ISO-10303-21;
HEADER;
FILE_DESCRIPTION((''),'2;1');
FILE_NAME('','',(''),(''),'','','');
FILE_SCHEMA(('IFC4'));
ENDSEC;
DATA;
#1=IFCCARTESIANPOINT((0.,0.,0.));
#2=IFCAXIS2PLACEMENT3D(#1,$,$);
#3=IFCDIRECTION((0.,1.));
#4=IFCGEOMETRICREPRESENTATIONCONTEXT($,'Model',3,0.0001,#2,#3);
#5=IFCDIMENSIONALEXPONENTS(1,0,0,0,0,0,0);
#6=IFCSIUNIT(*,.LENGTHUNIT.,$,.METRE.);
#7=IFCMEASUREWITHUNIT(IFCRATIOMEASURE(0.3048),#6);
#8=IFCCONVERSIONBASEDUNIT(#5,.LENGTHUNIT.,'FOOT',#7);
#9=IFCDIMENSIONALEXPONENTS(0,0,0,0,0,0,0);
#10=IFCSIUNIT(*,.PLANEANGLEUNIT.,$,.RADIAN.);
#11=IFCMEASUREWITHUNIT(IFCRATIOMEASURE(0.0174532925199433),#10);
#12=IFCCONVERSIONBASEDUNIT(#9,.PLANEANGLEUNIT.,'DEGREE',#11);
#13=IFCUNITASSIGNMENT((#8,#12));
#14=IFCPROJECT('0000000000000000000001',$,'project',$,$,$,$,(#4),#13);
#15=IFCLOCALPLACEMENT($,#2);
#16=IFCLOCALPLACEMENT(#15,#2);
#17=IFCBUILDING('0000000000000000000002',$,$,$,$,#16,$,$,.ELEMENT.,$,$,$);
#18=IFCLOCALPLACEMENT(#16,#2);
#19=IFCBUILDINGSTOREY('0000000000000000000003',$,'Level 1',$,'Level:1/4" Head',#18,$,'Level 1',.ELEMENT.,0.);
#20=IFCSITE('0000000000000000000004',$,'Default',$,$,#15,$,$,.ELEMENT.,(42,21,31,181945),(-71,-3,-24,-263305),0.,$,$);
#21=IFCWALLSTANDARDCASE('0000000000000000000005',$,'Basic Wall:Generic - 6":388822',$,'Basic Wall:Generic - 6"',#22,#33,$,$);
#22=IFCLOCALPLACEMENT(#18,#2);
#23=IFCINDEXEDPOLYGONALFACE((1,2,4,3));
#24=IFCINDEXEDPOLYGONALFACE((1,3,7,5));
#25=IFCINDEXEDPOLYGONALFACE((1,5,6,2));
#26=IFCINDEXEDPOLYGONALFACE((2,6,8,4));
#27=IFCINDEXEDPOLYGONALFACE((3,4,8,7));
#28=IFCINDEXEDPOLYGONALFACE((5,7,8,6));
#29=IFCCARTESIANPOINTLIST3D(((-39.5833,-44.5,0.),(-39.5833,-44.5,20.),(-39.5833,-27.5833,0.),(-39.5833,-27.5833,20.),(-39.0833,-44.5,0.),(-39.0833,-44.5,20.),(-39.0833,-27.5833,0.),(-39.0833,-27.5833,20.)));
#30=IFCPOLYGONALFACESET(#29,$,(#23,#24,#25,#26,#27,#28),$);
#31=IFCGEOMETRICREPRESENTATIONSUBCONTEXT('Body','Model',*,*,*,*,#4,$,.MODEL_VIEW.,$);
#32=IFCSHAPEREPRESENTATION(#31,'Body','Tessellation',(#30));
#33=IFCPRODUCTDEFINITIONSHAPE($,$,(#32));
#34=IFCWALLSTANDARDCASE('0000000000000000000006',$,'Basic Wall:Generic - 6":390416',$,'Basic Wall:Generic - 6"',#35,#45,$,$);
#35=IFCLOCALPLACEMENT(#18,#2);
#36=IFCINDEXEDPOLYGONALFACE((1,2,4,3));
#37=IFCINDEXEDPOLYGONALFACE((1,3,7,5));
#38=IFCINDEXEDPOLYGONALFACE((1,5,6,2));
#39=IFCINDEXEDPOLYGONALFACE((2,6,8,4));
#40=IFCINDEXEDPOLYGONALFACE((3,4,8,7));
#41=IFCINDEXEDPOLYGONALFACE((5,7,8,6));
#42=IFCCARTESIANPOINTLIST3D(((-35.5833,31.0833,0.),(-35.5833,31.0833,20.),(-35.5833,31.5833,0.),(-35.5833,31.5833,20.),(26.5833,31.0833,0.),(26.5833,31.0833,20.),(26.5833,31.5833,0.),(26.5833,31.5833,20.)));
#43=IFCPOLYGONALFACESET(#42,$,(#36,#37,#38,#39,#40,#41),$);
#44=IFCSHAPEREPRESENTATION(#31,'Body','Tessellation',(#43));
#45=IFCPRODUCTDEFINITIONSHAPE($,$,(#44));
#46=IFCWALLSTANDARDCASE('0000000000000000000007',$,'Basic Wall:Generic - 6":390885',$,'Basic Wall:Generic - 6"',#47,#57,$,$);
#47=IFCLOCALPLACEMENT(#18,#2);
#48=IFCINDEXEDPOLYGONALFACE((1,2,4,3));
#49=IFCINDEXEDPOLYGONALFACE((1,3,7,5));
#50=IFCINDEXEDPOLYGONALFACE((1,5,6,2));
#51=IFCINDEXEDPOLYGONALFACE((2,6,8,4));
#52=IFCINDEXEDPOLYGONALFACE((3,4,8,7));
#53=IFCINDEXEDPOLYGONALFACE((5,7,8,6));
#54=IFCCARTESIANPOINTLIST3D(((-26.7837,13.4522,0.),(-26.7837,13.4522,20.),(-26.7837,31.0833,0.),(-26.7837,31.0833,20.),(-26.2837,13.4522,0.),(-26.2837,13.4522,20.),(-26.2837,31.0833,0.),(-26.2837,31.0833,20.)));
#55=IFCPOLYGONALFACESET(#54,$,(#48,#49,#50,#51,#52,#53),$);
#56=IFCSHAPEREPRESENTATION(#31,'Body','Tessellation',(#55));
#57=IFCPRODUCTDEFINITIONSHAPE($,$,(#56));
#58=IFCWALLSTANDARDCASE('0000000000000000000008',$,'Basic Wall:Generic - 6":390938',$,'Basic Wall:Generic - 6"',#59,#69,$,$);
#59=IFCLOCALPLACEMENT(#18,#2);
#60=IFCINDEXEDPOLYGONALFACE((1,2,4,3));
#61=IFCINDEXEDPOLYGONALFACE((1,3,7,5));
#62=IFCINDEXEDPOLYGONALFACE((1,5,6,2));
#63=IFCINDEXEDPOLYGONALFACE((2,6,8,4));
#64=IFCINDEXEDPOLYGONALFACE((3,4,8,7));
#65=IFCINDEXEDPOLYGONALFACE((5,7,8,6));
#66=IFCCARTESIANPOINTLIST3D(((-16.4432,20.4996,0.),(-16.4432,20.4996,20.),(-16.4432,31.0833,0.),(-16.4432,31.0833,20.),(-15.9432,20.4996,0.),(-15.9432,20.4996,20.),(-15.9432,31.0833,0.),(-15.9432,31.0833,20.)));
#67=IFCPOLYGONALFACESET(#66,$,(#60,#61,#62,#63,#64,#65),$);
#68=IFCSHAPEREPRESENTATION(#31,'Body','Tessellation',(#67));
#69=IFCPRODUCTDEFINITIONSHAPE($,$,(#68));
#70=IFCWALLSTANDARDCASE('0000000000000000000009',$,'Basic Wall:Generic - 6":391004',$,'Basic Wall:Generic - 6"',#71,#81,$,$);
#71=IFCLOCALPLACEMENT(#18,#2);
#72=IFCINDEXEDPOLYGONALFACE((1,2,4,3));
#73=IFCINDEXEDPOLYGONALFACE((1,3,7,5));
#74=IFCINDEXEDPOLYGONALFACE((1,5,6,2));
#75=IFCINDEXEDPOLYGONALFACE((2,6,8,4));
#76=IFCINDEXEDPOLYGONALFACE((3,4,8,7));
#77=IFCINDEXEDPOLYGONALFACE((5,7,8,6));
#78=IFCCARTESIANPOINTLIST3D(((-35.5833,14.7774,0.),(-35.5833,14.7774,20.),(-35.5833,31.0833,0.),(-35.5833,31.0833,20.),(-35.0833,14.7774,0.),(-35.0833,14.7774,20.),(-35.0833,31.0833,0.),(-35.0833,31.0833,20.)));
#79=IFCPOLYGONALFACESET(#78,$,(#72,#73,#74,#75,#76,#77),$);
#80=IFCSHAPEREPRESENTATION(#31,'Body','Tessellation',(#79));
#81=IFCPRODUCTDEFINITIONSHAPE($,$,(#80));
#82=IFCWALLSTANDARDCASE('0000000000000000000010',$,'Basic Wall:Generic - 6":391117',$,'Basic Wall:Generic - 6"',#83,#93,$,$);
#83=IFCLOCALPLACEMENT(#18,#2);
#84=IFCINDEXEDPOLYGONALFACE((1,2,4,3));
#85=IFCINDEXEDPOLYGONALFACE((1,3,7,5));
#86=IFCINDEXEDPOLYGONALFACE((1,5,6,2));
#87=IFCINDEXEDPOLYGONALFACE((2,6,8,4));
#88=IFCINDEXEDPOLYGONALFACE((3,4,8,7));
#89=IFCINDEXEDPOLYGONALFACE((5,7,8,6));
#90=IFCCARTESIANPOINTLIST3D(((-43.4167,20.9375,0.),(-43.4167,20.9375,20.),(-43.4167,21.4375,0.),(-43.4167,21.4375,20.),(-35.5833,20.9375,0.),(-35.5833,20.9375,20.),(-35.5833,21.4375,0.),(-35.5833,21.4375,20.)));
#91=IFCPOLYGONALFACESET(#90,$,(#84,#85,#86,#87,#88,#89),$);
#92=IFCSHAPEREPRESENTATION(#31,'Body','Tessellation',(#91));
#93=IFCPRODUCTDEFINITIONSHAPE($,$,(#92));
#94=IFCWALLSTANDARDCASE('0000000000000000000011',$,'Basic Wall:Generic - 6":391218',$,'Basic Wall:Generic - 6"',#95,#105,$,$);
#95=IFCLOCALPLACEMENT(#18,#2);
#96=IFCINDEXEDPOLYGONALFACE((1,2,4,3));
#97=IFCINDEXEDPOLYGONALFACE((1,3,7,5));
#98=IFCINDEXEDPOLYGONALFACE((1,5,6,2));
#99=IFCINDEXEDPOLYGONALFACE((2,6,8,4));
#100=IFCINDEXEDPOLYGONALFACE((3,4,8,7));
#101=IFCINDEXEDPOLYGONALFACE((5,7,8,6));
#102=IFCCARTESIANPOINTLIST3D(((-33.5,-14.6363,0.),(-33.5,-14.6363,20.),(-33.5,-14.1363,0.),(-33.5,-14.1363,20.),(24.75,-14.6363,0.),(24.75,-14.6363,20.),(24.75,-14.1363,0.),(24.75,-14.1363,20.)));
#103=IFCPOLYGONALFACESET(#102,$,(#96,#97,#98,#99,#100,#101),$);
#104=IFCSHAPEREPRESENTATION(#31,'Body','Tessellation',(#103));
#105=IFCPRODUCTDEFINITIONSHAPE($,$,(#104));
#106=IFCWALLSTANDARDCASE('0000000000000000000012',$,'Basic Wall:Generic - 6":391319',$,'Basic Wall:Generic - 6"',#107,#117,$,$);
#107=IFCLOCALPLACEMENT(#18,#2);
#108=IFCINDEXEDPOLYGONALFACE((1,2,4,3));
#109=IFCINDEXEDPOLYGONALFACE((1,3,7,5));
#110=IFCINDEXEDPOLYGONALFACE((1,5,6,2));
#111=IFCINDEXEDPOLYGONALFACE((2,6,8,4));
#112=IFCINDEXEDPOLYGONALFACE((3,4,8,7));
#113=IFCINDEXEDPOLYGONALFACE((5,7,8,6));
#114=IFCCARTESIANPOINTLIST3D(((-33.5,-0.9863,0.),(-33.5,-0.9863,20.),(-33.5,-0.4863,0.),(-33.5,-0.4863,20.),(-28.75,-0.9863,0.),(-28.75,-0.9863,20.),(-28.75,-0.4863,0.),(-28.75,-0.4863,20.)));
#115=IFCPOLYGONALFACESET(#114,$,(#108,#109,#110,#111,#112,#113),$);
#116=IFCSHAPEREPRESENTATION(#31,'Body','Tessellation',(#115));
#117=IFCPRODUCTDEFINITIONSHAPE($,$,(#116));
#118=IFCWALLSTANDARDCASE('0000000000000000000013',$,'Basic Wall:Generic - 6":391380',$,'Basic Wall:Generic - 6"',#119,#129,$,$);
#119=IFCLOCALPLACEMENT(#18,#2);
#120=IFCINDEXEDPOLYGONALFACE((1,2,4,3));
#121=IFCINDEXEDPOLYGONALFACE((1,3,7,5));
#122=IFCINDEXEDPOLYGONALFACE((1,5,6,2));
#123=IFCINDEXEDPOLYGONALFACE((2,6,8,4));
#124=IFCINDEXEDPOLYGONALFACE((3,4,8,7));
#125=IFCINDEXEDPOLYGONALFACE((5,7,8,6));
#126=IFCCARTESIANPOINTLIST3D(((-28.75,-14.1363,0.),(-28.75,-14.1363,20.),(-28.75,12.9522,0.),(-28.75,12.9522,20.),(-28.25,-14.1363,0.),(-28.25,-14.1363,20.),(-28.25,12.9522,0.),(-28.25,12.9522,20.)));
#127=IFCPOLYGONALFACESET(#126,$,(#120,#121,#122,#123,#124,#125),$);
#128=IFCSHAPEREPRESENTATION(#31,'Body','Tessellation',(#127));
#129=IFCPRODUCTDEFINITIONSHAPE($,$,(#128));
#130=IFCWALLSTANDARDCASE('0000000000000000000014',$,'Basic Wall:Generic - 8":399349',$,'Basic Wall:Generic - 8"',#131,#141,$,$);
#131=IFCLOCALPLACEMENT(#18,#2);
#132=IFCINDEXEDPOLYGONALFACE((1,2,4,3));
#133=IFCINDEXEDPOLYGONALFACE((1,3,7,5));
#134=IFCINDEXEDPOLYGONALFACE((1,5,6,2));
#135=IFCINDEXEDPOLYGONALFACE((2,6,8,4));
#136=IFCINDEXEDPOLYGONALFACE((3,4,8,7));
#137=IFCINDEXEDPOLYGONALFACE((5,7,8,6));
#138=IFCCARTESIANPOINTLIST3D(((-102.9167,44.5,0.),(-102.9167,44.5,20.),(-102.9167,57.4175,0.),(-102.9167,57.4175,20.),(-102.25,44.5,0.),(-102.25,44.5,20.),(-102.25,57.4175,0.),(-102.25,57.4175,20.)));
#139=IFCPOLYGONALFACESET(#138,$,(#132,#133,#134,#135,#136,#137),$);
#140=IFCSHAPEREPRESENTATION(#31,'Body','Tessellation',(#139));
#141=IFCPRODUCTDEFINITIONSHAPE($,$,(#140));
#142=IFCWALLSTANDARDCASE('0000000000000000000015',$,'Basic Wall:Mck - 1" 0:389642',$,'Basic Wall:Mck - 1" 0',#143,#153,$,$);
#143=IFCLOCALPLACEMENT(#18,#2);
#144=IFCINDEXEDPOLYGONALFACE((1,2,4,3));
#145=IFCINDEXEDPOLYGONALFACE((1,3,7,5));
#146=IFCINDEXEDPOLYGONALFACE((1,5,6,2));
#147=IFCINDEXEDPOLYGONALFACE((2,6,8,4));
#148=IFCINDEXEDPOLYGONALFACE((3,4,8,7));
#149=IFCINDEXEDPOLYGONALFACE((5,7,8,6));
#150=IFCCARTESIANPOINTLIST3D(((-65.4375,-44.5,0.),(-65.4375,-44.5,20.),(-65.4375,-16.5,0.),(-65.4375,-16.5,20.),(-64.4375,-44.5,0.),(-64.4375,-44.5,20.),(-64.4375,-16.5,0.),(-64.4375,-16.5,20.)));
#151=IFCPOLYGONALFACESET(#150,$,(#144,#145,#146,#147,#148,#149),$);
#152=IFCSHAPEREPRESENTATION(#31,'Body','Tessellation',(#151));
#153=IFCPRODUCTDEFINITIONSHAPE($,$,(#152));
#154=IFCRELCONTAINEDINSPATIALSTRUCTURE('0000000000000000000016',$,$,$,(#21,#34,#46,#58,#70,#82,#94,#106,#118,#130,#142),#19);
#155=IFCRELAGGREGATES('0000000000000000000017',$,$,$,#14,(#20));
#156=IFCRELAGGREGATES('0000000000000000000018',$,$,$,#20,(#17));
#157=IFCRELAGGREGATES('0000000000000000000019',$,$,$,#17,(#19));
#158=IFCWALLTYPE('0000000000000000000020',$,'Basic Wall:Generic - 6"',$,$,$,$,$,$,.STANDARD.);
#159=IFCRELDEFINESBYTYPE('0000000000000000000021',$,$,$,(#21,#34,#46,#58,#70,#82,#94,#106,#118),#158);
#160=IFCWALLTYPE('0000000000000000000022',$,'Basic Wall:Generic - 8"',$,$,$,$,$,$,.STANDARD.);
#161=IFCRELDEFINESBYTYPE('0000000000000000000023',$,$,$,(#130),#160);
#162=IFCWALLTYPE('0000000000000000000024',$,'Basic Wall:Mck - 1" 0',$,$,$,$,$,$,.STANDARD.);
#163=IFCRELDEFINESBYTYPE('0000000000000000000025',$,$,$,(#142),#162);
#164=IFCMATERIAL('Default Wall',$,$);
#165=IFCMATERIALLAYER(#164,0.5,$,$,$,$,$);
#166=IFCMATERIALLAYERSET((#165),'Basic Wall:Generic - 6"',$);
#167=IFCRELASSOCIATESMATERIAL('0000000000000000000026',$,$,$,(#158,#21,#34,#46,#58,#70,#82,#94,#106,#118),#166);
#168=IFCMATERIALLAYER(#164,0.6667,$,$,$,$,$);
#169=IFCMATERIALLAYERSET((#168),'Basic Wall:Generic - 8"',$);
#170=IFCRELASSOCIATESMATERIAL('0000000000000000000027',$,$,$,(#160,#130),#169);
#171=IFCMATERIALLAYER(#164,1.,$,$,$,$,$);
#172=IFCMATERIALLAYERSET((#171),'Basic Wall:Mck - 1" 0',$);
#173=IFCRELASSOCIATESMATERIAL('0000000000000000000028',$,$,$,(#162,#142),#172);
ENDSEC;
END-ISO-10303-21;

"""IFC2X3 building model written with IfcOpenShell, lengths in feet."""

from ifc_helpers import new_model, entity, si_unit, converted_unit, direction, frame, frame_2d, origin, place, context, subcontext, project, spatial, rectangle, extrude, material, layer, layer_set, layer_usage, type_object, element, save


model = new_model("IFC2X3")

# Units and contexts
model_context = context("Model", 3, precision=0.0001, world=origin(), true_north=direction((0.0, 1.0)))
body_context = subcontext(model_context, "Body", "Model", "MODEL_VIEW")
ifc_project = project(units=[converted_unit("LENGTHUNIT", "FOOT", entity("IfcRatioMeasure", 0.3048), si_unit("LENGTHUNIT", "METRE"), dimensions=[1, 0, 0, 0, 0, 0, 0]), converted_unit("PLANEANGLEUNIT", "DEGREE", entity("IfcRatioMeasure", 0.0174532925199433), si_unit("PLANEANGLEUNIT", "RADIAN"), dimensions=[0, 0, 0, 0, 0, 0, 0])], contexts=[model_context])

# Site, building, storey
site_placement = place(None, origin())
site = spatial("IfcSite", under=ifc_project, at=site_placement, Name="Default", CompositionType="ELEMENT", RefLatitude=(42, 21, 31, 181945), RefLongitude=(-71, -3, -24, -263305), RefElevation=0.0)
building_placement = place(site_placement, origin())
building = spatial("IfcBuilding", under=site, at=building_placement, CompositionType="ELEMENT")
storey_placement = place(building_placement, origin())
storey = spatial("IfcBuildingStorey", under=building, at=storey_placement, Name="Level 1", ObjectType="Level:1/4\" Head", LongName="Level 1", CompositionType="ELEMENT", Elevation=0.0)

# Walls
ifc_material = material(Name="Default Wall")
ifc_layer_1 = layer(ifc_material, 0.5)
ifc_layer_set_1 = layer_set([ifc_layer_1], Name="Basic Wall:Generic - 6\"")
wall_type_1 = type_object("IfcWallType", Name="Basic Wall:Generic - 6\"", PredefinedType="STANDARD", material=ifc_layer_set_1)
ifc_layer_usage_1 = layer_usage(ifc_layer_set_1, "AXIS2", "NEGATIVE", 0.25)
wall_1_placement = place(storey_placement, frame((-39.3333, -27.5833, 0.0), z_axis=(0.0, 0.0, 1.0), x_axis=(0.0, -1.0, 0.0)))
element("IfcWallStandardCase", 1, at=wall_1_placement, inside=storey, type_object=wall_type_1, material=ifc_layer_usage_1, Name="Basic Wall:Generic - 6\":388822", ObjectType="Basic Wall:Generic - 6\"", context=body_context, shape_type="SweptSolid", body=[
    extrude(rectangle(XDim=16.9167, YDim=0.5, at=frame_2d((8.4583, 0.0), x_axis=(-1.0, 0.0))), origin(), (0.0, 0.0, 1.0), 20.0),
])
ifc_layer_usage_2 = layer_usage(ifc_layer_set_1, "AXIS2", "NEGATIVE", 0.25)
wall_2_placement = place(storey_placement, frame((-35.5833, 31.3333, 0.0)))
element("IfcWallStandardCase", 2, at=wall_2_placement, inside=storey, type_object=wall_type_1, material=ifc_layer_usage_2, Name="Basic Wall:Generic - 6\":390416", ObjectType="Basic Wall:Generic - 6\"", context=body_context, shape_type="SweptSolid", body=[
    extrude(rectangle(XDim=62.1667, YDim=0.5, at=frame_2d((31.0833, 0.0), x_axis=(-1.0, 0.0))), origin(), (0.0, 0.0, 1.0), 20.0),
])
ifc_layer_usage_3 = layer_usage(ifc_layer_set_1, "AXIS2", "NEGATIVE", 0.25)
wall_3_placement = place(storey_placement, frame((-26.5337, 13.4522, 0.0), z_axis=(0.0, 0.0, 1.0), x_axis=(0.0, 1.0, 0.0)))
element("IfcWallStandardCase", 3, at=wall_3_placement, inside=storey, type_object=wall_type_1, material=ifc_layer_usage_3, Name="Basic Wall:Generic - 6\":390885", ObjectType="Basic Wall:Generic - 6\"", context=body_context, shape_type="SweptSolid", body=[
    extrude(rectangle(XDim=17.6311, YDim=0.5, at=frame_2d((8.8156, 0.0), x_axis=(-1.0, 0.0))), origin(), (0.0, 0.0, 1.0), 20.0),
])
ifc_layer_usage_4 = layer_usage(ifc_layer_set_1, "AXIS2", "NEGATIVE", 0.25)
wall_4_placement = place(storey_placement, frame((-16.1932, 31.0833, 0.0), z_axis=(0.0, 0.0, 1.0), x_axis=(0.0, -1.0, 0.0)))
element("IfcWallStandardCase", 4, at=wall_4_placement, inside=storey, type_object=wall_type_1, material=ifc_layer_usage_4, Name="Basic Wall:Generic - 6\":390938", ObjectType="Basic Wall:Generic - 6\"", context=body_context, shape_type="SweptSolid", body=[
    extrude(rectangle(XDim=10.5838, YDim=0.5, at=frame_2d((5.2919, 0.0), x_axis=(-1.0, 0.0))), origin(), (0.0, 0.0, 1.0), 20.0),
])
ifc_layer_usage_5 = layer_usage(ifc_layer_set_1, "AXIS2", "NEGATIVE", 0.25)
wall_5_placement = place(storey_placement, frame((-35.3333, 31.0833, 0.0), z_axis=(0.0, 0.0, 1.0), x_axis=(0.0, -1.0, 0.0)))
element("IfcWallStandardCase", 5, at=wall_5_placement, inside=storey, type_object=wall_type_1, material=ifc_layer_usage_5, Name="Basic Wall:Generic - 6\":391004", ObjectType="Basic Wall:Generic - 6\"", context=body_context, shape_type="SweptSolid", body=[
    extrude(rectangle(XDim=16.3059, YDim=0.5, at=frame_2d((8.153, 0.0), x_axis=(-1.0, 0.0))), origin(), (0.0, 0.0, 1.0), 20.0),
])
ifc_layer_usage_6 = layer_usage(ifc_layer_set_1, "AXIS2", "NEGATIVE", 0.25)
wall_6_placement = place(storey_placement, frame((-43.4167, 21.1875, 0.0)))
element("IfcWallStandardCase", 6, at=wall_6_placement, inside=storey, type_object=wall_type_1, material=ifc_layer_usage_6, Name="Basic Wall:Generic - 6\":391117", ObjectType="Basic Wall:Generic - 6\"", context=body_context, shape_type="SweptSolid", body=[
    extrude(rectangle(XDim=7.8333, YDim=0.5, at=frame_2d((3.9167, 0.0), x_axis=(-1.0, 0.0))), origin(), (0.0, 0.0, 1.0), 20.0),
])
ifc_layer_usage_7 = layer_usage(ifc_layer_set_1, "AXIS2", "NEGATIVE", 0.25)
wall_7_placement = place(storey_placement, frame((-33.5, -14.3863, 0.0)))
element("IfcWallStandardCase", 7, at=wall_7_placement, inside=storey, type_object=wall_type_1, material=ifc_layer_usage_7, Name="Basic Wall:Generic - 6\":391218", ObjectType="Basic Wall:Generic - 6\"", context=body_context, shape_type="SweptSolid", body=[
    extrude(rectangle(XDim=58.25, YDim=0.5, at=frame_2d((29.125, 0.0), x_axis=(-1.0, 0.0))), origin(), (0.0, 0.0, 1.0), 20.0),
])
ifc_layer_usage_8 = layer_usage(ifc_layer_set_1, "AXIS2", "NEGATIVE", 0.25)
wall_8_placement = place(storey_placement, frame((-33.5, -0.7363, 0.0)))
element("IfcWallStandardCase", 8, at=wall_8_placement, inside=storey, type_object=wall_type_1, material=ifc_layer_usage_8, Name="Basic Wall:Generic - 6\":391319", ObjectType="Basic Wall:Generic - 6\"", context=body_context, shape_type="SweptSolid", body=[
    extrude(rectangle(XDim=4.75, YDim=0.5, at=frame_2d((2.375, 0.0), x_axis=(-1.0, 0.0))), origin(), (0.0, 0.0, 1.0), 20.0),
])
ifc_layer_usage_9 = layer_usage(ifc_layer_set_1, "AXIS2", "NEGATIVE", 0.25)
wall_9_placement = place(storey_placement, frame((-28.5, -14.1363, 0.0), z_axis=(0.0, 0.0, 1.0), x_axis=(0.0, 1.0, 0.0)))
element("IfcWallStandardCase", 9, at=wall_9_placement, inside=storey, type_object=wall_type_1, material=ifc_layer_usage_9, Name="Basic Wall:Generic - 6\":391380", ObjectType="Basic Wall:Generic - 6\"", context=body_context, shape_type="SweptSolid", body=[
    extrude(rectangle(XDim=27.0885, YDim=0.5, at=frame_2d((13.5443, 0.0), x_axis=(-1.0, 0.0))), origin(), (0.0, 0.0, 1.0), 20.0),
])
ifc_layer_2 = layer(ifc_material, 0.6667)
ifc_layer_set_2 = layer_set([ifc_layer_2], Name="Basic Wall:Generic - 8\"")
ifc_layer_usage_10 = layer_usage(ifc_layer_set_2, "AXIS2", "NEGATIVE", 0.3333)
wall_type_2 = type_object("IfcWallType", Name="Basic Wall:Generic - 8\"", PredefinedType="STANDARD", material=ifc_layer_set_2)
wall_10_placement = place(storey_placement, frame((-102.5833, 44.5, 0.0), z_axis=(0.0, 0.0, 1.0), x_axis=(0.0, 1.0, 0.0)))
element("IfcWallStandardCase", 10, at=wall_10_placement, inside=storey, type_object=wall_type_2, material=ifc_layer_usage_10, Name="Basic Wall:Generic - 8\":399349", ObjectType="Basic Wall:Generic - 8\"", context=body_context, shape_type="SweptSolid", body=[
    extrude(rectangle(XDim=12.9175, YDim=0.6667, at=frame_2d((6.4588, 0.0), x_axis=(-1.0, 0.0))), origin(), (0.0, 0.0, 1.0), 20.0),
])
ifc_layer_3 = layer(ifc_material, 1.0)
ifc_layer_set_3 = layer_set([ifc_layer_3], Name="Basic Wall:Mck - 1\" 0")
ifc_layer_usage_11 = layer_usage(ifc_layer_set_3, "AXIS2", "NEGATIVE", 0.5)
wall_type_3 = type_object("IfcWallType", Name="Basic Wall:Mck - 1\" 0", PredefinedType="STANDARD", material=ifc_layer_set_3)
wall_11_placement = place(storey_placement, frame((-64.9375, -44.5, 0.0), z_axis=(0.0, 0.0, 1.0), x_axis=(0.0, 1.0, 0.0)))
element("IfcWallStandardCase", 11, at=wall_11_placement, inside=storey, type_object=wall_type_3, material=ifc_layer_usage_11, Name="Basic Wall:Mck - 1\" 0:389642", ObjectType="Basic Wall:Mck - 1\" 0", context=body_context, shape_type="SweptSolid", body=[
    extrude(rectangle(XDim=28.0, YDim=1.0, at=frame_2d((14.0, 0.0), x_axis=(-1.0, 0.0))), origin(), (0.0, 0.0, 1.0), 20.0),
])

save(model, "model.ifc")
